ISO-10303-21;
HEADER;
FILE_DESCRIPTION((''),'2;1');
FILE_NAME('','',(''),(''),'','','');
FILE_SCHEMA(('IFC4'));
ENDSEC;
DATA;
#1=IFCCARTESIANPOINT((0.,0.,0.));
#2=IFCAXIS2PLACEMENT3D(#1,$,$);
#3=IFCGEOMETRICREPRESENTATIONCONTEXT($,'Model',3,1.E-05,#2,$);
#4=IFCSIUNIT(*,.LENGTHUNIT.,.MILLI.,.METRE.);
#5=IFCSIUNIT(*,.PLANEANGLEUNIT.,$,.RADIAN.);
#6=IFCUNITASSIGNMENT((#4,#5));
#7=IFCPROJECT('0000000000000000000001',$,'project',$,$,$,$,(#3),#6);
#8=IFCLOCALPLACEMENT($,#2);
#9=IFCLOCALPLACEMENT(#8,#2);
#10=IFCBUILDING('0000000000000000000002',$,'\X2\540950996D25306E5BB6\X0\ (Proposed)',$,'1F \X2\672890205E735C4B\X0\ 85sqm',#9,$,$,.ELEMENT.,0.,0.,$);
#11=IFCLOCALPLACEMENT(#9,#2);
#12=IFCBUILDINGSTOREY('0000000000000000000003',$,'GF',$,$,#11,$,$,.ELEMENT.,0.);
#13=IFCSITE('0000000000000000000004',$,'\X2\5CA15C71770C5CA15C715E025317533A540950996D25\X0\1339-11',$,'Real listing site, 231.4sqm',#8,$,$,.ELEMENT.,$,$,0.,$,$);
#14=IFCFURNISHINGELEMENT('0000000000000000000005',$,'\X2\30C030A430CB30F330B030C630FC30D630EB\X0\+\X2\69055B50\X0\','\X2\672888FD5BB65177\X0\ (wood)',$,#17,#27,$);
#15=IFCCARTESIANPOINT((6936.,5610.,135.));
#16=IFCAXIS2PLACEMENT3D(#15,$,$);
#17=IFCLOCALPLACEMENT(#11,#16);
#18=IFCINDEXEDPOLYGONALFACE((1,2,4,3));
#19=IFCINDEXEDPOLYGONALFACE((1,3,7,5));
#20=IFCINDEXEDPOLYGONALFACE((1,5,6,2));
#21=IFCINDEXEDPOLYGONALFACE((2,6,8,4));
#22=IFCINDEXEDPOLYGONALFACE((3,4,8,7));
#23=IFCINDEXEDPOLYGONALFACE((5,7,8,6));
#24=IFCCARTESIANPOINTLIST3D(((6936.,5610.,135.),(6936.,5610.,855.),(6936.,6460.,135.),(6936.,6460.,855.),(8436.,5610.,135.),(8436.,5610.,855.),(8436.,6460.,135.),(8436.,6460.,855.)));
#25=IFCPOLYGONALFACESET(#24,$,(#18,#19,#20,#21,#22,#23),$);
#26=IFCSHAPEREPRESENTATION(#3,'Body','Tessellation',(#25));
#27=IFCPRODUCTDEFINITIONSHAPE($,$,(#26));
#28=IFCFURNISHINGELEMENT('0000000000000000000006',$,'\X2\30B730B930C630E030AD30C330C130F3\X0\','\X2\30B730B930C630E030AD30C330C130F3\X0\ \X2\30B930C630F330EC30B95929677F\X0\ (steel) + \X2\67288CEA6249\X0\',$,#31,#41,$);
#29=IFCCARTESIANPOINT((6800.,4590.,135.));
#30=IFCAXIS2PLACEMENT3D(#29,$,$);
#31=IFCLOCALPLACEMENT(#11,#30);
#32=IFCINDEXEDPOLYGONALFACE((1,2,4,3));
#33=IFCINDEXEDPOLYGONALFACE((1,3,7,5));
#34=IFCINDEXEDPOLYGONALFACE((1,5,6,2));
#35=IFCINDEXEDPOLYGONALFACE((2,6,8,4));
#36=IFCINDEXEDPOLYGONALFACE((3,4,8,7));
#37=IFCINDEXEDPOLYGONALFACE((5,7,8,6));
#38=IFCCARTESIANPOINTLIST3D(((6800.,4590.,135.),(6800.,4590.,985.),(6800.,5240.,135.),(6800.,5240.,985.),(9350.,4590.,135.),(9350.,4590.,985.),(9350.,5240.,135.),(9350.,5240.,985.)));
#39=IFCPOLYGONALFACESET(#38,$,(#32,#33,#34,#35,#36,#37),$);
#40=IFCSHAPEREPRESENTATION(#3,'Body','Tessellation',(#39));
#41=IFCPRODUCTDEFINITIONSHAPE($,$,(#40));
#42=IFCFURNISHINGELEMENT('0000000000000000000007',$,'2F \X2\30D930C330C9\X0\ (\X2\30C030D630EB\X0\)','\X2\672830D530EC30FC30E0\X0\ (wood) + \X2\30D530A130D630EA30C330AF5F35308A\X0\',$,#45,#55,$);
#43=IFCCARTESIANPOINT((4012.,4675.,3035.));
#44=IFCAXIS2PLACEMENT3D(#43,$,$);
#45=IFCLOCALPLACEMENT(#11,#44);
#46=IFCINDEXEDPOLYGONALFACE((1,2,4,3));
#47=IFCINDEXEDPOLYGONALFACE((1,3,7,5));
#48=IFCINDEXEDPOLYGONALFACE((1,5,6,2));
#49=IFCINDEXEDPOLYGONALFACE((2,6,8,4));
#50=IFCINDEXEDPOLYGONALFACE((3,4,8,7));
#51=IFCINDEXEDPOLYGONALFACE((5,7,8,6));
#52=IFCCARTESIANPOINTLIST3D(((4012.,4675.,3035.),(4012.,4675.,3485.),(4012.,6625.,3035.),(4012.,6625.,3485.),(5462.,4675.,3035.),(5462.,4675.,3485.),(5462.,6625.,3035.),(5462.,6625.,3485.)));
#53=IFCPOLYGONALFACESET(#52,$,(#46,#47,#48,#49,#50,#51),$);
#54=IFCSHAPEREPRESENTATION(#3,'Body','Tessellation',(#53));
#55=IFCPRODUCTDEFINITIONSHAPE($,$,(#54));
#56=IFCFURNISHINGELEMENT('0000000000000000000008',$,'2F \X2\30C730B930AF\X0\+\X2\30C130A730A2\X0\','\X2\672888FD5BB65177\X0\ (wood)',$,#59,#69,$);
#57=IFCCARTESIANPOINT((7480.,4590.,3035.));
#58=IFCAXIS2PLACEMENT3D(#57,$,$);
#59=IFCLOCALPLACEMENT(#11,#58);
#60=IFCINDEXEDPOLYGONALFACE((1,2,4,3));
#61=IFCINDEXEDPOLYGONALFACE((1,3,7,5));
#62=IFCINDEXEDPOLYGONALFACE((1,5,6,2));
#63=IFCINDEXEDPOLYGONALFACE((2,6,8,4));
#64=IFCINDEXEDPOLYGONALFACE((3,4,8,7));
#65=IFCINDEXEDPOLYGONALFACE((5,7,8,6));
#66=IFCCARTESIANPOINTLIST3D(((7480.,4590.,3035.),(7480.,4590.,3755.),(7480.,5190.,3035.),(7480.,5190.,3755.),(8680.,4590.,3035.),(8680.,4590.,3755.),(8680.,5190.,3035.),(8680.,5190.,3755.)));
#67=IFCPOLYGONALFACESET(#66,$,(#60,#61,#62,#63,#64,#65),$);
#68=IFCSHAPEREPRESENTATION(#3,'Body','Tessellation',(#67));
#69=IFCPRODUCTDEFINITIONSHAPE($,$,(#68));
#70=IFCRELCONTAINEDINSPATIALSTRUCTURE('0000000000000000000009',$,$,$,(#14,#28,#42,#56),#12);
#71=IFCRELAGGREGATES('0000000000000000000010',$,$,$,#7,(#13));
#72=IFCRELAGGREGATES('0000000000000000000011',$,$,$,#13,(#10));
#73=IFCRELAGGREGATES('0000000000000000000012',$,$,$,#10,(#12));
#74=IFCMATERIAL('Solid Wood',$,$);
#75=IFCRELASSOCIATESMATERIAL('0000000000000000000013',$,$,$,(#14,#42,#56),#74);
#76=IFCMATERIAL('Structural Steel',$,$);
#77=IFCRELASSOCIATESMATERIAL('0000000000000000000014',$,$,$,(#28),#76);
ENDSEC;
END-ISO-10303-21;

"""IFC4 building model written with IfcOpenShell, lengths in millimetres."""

from ifc_helpers import new_model, si_unit, frame, frame_2d, origin, place, context, project, spatial, rectangle, extrude, material, element, save


model = new_model("IFC4")

# Units and contexts
model_context = context("Model", 3, precision=1e-05, world=origin())
ifc_project = project(units=[si_unit("LENGTHUNIT", "METRE", prefix="MILLI"), si_unit("PLANEANGLEUNIT", "RADIAN")], contexts=[model_context])

# Site, building, storey
site_placement = place(None, origin())
site = spatial("IfcSite", under=ifc_project, at=site_placement, Name="岡山県岡山市北区吉備津1339-11", ObjectType="Real listing site, 231.4sqm", CompositionType="ELEMENT", RefElevation=0.0)
building_placement = place(site_placement, origin())
building = spatial("IfcBuilding", under=site, at=building_placement, Name="吉備津の家 (Proposed)", ObjectType="1F 木造平屋 85sqm", CompositionType="ELEMENT", ElevationOfRefHeight=0.0, ElevationOfTerrain=0.0)
storey_placement = place(building_placement, origin())
storey = spatial("IfcBuildingStorey", under=building, at=storey_placement, Name="GF", CompositionType="ELEMENT", Elevation=0.0)

# Shared definitions
ifc_material_1 = material(Name="Solid Wood")

# Shared definitions
ifc_material_2 = material(Name="Structural Steel")

# Furnishing elements
furnishing_1_placement = place(storey_placement, frame((6936.0, 5610.0, 135.0)))
element("IfcFurnishingElement", 1, at=furnishing_1_placement, inside=storey, material=ifc_material_1, Name="ダイニングテーブル+椅子", Description="木製家具 (wood)", context=model_context, shape_type="SweptSolid", body=[
    extrude(rectangle(XDim=1500.0, YDim=850.0, at=frame_2d((750.0, 425.0))), frame((6936.0, 5610.0, 135.0)), (0.0, 0.0, 1.0), 720.0),
])
furnishing_2_placement = place(storey_placement, frame((6800.0, 4590.0, 135.0)))
element("IfcFurnishingElement", 2, at=furnishing_2_placement, inside=storey, material=ifc_material_2, Name="システムキッチン", Description="システムキッチン ステンレス天板 (steel) + 木質扉", context=model_context, shape_type="SweptSolid", body=[
    extrude(rectangle(XDim=2550.0, YDim=650.0, at=frame_2d((1275.0, 325.0))), frame((6800.0, 4590.0, 135.0)), (0.0, 0.0, 1.0), 850.0),
])
furnishing_3_placement = place(storey_placement, frame((4012.0, 4675.0, 3035.0)))
element("IfcFurnishingElement", 3, at=furnishing_3_placement, inside=storey, material=ifc_material_1, Name="2F ベッド (ダブル)", Description="木フレーム (wood) + ファブリック張り", context=model_context, shape_type="SweptSolid", body=[
    extrude(rectangle(XDim=1450.0, YDim=1950.0, at=frame_2d((725.0, 975.0))), frame((4012.0, 4675.0, 3035.0)), (0.0, 0.0, 1.0), 450.0),
])
furnishing_4_placement = place(storey_placement, frame((7480.0, 4590.0, 3035.0)))
element("IfcFurnishingElement", 4, at=furnishing_4_placement, inside=storey, material=ifc_material_1, Name="2F デスク+チェア", Description="木製家具 (wood)", context=model_context, shape_type="SweptSolid", body=[
    extrude(rectangle(XDim=1200.0, YDim=600.0, at=frame_2d((600.0, 300.0))), frame((7480.0, 4590.0, 3035.0)), (0.0, 0.0, 1.0), 720.0),
])

save(model, "model.ifc")
